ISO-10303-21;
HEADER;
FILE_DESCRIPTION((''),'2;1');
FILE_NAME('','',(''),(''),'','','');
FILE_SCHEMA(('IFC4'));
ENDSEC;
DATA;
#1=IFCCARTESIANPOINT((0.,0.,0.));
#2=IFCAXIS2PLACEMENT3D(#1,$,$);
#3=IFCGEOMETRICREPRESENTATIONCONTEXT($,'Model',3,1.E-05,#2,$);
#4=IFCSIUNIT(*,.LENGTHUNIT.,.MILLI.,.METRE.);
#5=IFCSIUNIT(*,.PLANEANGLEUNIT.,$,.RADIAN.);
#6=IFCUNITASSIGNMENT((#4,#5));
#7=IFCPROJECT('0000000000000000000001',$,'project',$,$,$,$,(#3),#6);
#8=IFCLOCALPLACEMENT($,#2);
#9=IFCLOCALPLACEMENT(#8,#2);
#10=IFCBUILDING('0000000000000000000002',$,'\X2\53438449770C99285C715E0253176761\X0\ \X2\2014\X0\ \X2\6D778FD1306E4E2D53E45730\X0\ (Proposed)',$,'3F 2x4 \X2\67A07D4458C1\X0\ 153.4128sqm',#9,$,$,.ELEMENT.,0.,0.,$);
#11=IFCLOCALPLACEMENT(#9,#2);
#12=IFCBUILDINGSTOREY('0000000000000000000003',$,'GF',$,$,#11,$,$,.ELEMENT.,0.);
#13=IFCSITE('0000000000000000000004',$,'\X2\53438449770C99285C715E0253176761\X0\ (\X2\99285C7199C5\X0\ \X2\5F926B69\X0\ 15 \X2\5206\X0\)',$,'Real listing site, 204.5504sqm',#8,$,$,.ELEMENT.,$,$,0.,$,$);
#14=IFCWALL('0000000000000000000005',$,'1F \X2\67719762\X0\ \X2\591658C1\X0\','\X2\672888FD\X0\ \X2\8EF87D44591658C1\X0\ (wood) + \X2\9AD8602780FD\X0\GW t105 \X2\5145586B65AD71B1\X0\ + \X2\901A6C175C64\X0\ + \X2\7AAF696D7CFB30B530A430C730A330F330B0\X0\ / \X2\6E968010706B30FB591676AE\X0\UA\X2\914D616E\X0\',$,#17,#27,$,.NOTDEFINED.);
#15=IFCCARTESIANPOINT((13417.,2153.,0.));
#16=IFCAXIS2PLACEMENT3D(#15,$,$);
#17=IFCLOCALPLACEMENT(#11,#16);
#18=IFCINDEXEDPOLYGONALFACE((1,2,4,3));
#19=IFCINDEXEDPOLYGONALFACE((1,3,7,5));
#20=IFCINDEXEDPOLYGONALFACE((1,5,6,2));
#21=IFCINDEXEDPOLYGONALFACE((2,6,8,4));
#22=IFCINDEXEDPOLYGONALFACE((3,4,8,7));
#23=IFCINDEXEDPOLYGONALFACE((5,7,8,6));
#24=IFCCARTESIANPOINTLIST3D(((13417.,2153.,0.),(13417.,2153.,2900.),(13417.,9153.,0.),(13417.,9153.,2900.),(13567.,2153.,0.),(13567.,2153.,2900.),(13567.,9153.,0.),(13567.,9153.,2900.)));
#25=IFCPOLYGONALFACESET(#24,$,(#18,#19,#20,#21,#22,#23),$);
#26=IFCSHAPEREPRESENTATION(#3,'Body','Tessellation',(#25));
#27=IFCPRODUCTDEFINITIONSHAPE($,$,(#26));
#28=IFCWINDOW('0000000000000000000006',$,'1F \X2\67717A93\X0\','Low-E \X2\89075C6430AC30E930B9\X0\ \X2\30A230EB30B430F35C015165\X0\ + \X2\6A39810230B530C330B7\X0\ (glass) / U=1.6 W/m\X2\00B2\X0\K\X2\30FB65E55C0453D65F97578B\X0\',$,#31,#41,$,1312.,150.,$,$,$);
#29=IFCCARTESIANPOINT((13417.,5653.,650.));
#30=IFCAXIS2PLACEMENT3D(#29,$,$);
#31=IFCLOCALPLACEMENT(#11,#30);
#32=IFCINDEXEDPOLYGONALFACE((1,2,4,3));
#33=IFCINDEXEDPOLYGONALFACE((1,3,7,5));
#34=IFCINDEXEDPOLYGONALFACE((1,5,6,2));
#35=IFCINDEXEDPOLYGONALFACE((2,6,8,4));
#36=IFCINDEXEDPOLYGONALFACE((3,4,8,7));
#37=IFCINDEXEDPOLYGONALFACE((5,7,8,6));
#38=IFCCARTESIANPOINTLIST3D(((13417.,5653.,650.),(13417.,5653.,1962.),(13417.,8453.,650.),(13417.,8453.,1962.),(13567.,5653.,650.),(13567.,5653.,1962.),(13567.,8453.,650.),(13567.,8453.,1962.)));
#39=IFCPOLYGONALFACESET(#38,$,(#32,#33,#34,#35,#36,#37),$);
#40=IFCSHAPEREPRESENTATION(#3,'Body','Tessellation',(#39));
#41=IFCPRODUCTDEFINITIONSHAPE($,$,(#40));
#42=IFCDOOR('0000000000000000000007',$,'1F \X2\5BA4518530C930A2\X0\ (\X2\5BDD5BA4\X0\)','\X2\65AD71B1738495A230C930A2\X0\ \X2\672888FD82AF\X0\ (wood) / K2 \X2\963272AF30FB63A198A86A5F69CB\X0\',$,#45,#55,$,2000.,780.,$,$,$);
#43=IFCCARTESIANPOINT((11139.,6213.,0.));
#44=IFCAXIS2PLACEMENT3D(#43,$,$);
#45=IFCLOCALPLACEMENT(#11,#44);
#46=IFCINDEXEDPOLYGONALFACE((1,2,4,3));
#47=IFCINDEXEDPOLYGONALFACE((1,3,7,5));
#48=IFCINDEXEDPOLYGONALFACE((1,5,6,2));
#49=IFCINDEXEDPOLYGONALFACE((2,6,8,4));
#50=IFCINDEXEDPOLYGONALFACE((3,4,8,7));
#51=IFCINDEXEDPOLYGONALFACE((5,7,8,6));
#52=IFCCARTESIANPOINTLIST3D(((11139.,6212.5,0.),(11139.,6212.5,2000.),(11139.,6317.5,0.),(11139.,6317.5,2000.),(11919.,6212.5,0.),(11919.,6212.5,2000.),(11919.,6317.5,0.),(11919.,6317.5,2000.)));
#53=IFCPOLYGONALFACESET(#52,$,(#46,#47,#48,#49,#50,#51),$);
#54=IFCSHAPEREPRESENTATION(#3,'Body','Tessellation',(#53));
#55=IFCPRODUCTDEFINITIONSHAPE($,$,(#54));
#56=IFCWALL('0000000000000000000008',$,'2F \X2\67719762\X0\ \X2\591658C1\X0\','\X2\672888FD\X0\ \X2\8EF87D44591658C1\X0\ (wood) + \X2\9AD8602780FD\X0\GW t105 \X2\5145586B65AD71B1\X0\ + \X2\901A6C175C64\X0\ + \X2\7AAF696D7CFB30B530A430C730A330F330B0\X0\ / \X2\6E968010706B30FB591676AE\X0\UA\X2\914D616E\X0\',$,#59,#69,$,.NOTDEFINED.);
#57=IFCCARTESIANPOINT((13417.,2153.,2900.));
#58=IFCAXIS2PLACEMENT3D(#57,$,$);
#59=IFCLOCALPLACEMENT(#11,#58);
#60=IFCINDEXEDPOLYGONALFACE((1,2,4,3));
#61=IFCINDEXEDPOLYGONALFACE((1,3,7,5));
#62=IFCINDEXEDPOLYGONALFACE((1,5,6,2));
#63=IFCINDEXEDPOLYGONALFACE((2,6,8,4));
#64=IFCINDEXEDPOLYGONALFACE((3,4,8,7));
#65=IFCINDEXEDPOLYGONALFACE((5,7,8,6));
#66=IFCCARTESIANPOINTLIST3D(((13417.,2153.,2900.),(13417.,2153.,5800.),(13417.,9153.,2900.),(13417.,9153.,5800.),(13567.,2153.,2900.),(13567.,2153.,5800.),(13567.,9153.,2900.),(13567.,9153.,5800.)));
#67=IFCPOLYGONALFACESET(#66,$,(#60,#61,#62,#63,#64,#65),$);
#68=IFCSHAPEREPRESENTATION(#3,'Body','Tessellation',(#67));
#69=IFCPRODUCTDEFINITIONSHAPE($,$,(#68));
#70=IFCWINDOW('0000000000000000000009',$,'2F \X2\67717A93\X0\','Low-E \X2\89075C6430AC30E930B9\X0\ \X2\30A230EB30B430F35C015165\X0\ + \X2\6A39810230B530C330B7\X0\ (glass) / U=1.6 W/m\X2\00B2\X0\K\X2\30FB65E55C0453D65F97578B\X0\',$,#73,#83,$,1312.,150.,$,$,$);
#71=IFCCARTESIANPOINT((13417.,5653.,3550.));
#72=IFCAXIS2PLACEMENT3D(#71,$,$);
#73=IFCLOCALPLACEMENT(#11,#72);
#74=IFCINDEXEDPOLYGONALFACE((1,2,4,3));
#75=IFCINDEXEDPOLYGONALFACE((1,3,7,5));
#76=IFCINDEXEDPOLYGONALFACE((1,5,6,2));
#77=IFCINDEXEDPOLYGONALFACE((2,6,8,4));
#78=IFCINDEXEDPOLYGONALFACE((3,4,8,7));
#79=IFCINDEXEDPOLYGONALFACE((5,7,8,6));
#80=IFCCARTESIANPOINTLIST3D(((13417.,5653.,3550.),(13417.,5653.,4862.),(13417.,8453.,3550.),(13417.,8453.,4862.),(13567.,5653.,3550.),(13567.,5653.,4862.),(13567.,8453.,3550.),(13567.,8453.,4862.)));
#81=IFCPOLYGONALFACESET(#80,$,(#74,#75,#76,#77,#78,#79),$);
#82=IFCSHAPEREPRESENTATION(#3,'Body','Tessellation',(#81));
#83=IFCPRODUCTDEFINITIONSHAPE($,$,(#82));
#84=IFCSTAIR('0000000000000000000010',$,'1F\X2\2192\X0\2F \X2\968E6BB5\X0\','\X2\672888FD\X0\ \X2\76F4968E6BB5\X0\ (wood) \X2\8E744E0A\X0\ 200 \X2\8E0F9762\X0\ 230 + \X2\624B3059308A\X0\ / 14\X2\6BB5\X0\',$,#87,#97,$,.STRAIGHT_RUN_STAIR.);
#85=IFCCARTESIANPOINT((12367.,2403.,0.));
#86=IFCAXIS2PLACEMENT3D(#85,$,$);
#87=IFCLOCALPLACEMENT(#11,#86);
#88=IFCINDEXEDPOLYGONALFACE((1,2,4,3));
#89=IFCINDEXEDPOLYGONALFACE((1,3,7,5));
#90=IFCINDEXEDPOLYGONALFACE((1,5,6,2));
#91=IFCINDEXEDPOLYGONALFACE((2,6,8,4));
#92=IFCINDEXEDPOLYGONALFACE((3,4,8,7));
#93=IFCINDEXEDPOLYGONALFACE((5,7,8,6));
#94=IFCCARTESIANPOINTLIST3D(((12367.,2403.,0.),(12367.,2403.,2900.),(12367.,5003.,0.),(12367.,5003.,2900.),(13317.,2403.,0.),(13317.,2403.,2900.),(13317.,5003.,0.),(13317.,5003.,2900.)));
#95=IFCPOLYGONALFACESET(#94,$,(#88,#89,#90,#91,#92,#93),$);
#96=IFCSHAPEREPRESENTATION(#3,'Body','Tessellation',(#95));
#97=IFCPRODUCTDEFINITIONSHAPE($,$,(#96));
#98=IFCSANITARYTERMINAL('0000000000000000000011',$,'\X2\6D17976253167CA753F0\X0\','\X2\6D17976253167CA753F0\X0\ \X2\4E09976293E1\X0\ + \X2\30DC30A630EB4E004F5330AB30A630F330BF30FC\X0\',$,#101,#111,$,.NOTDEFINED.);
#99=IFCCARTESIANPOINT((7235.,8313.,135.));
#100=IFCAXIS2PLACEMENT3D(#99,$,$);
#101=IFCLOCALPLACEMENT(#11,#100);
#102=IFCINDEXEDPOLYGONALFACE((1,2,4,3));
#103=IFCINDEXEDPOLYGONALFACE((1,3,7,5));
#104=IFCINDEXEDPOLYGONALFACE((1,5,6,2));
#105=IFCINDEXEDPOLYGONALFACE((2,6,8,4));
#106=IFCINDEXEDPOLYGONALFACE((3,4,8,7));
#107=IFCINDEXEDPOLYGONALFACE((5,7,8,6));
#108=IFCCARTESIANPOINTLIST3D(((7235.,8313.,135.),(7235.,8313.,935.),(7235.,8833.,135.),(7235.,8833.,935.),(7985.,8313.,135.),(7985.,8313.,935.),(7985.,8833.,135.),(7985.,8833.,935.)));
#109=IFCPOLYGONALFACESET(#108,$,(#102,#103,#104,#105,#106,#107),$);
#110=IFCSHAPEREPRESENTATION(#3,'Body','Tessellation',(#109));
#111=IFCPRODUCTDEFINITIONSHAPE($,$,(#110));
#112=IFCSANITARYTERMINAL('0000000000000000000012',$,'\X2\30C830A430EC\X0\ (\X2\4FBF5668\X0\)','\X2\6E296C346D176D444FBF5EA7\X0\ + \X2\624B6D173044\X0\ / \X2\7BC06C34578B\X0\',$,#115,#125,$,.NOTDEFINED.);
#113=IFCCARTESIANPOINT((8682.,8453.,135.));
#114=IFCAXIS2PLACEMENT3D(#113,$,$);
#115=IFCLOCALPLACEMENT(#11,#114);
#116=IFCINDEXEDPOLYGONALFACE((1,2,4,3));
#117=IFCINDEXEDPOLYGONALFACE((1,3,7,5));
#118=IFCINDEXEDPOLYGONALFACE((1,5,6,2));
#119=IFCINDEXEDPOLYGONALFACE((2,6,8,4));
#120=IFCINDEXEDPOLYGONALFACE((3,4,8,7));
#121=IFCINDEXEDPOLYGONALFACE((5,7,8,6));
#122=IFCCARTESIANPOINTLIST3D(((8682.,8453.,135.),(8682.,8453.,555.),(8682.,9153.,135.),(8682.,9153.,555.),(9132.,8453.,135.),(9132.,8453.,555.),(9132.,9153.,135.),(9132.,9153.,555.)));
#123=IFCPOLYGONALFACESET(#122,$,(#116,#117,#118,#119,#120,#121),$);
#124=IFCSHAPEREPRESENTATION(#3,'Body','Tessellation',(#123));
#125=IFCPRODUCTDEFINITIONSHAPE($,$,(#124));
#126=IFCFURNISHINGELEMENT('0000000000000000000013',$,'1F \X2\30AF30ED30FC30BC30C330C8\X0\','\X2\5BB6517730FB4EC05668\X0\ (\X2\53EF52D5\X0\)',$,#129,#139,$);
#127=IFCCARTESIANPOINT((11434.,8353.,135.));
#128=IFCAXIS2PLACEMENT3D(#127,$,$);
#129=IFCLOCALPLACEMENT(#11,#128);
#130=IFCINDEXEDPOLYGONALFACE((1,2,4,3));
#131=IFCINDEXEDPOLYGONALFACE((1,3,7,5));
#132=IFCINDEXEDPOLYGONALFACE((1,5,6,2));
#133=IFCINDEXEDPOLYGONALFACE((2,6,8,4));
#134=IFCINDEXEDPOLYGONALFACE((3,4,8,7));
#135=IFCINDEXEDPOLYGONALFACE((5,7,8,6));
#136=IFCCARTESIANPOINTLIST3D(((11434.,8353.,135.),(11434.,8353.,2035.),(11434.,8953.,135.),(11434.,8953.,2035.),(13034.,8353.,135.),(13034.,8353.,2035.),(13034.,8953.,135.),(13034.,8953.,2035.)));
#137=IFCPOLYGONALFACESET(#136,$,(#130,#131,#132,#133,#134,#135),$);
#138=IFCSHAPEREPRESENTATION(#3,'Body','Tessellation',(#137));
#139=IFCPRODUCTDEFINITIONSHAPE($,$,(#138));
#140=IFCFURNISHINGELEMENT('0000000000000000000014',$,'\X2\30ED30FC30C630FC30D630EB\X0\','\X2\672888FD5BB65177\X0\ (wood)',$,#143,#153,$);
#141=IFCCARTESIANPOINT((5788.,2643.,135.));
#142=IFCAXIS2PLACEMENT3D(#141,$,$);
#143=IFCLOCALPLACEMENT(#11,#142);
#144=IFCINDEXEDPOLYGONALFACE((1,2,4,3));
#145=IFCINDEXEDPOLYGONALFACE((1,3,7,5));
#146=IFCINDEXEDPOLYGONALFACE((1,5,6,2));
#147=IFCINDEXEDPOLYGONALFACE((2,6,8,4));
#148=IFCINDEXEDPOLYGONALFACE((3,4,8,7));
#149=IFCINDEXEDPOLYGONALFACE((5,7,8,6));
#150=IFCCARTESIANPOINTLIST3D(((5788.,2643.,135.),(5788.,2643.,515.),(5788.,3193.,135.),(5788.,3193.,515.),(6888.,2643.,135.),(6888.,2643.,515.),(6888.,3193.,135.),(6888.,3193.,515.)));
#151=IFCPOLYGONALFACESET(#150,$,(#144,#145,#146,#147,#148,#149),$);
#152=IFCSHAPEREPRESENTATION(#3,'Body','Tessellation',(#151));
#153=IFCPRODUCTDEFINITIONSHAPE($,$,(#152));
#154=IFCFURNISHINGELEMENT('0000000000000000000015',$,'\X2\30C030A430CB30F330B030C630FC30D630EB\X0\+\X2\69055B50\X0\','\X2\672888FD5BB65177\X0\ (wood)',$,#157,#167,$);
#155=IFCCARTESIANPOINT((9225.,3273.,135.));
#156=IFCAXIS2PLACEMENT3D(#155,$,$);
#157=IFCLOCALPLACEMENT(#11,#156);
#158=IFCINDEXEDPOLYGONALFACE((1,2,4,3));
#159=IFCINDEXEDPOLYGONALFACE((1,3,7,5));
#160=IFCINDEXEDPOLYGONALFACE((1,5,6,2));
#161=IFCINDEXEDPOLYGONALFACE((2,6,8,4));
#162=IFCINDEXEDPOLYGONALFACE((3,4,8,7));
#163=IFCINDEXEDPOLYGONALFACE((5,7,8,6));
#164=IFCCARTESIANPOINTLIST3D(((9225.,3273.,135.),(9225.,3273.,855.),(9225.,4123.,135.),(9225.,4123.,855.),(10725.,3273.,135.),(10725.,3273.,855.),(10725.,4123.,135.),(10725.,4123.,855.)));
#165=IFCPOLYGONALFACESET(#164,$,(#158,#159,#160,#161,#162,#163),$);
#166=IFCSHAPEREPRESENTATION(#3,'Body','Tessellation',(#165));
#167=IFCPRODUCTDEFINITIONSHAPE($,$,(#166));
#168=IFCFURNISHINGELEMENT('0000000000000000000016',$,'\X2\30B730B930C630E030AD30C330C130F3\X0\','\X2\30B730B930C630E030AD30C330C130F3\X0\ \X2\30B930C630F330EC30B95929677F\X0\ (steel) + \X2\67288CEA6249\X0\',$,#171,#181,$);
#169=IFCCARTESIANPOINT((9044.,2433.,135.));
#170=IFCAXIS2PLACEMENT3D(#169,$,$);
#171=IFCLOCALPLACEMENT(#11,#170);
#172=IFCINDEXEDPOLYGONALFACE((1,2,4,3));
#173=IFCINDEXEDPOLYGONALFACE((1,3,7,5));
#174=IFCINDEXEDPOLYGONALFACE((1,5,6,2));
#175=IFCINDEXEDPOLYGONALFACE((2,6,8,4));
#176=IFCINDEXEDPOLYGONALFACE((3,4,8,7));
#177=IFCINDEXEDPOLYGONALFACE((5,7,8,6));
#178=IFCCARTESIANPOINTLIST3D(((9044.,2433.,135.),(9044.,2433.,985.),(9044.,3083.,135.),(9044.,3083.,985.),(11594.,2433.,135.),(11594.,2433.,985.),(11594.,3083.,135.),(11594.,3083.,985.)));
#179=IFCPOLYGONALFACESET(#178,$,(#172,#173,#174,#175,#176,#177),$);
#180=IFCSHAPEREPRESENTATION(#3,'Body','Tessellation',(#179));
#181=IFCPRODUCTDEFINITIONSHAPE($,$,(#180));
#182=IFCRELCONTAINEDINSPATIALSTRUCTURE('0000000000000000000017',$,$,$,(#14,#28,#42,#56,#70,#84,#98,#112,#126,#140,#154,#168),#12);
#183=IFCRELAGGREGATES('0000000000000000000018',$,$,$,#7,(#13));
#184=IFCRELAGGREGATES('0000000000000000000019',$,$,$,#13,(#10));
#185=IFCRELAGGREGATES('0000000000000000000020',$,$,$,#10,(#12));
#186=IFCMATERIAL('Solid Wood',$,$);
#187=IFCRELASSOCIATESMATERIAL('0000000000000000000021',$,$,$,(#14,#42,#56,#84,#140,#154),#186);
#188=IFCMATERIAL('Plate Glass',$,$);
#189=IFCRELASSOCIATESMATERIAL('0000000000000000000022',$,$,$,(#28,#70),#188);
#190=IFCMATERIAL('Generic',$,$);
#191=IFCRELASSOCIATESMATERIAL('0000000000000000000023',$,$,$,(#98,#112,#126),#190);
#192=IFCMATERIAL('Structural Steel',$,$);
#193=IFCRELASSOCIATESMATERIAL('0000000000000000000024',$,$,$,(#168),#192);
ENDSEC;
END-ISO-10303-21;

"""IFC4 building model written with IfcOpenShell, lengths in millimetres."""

from ifc_helpers import new_model, si_unit, frame, frame_2d, origin, place, context, project, spatial, rectangle, extrude, material, element, fill, save


model = new_model("IFC4")

# Units and contexts
model_context = context("Model", 3, precision=1e-05, world=origin())
ifc_project = project(units=[si_unit("LENGTHUNIT", "METRE", prefix="MILLI"), si_unit("PLANEANGLEUNIT", "RADIAN")], contexts=[model_context])

# Site, building, storey
site_placement = place(None, origin())
site = spatial("IfcSite", under=ifc_project, at=site_placement, Name="千葉県館山市北条 (館山駅 徒歩 15 分)", ObjectType="Real listing site, 204.5504sqm", CompositionType="ELEMENT", RefElevation=0.0)
building_placement = place(site_placement, origin())
building = spatial("IfcBuilding", under=site, at=building_placement, Name="千葉県館山市北条 — 海近の中古地 (Proposed)", ObjectType="3F 2x4 枠組壁 153.4128sqm", CompositionType="ELEMENT", ElevationOfRefHeight=0.0, ElevationOfTerrain=0.0)
storey_placement = place(building_placement, origin())
storey = spatial("IfcBuildingStorey", under=building, at=storey_placement, Name="GF", CompositionType="ELEMENT", Elevation=0.0)

# Wall, opening, window
ifc_material_1 = material(Name="Solid Wood")
wall_1_placement = place(storey_placement, frame((13417.0, 2153.0, 0.0)))
wall_1 = element("IfcWall", 1, at=wall_1_placement, inside=storey, material=ifc_material_1, Name="1F 東面 外壁", Description="木製 軸組外壁 (wood) + 高性能GW t105 充填断熱 + 通気層 + 窯業系サイディング / 準耐火・外皮UA配慮", PredefinedType="NOTDEFINED", context=model_context, shape_type="SweptSolid", body=[
    extrude(rectangle(XDim=150.0, YDim=7000.0, at=frame_2d((75.0, 3500.0))), frame((13417.0, 2153.0, 0.0)), (0.0, 0.0, 1.0), 2900.0),
])
opening_1_placement = place(storey_placement, frame((13417.0, 5653.0, 650.0)))
opening_1 = element("IfcOpeningElement", 2, at=opening_1_placement, cuts=wall_1, PredefinedType="NOTDEFINED", context=model_context, shape_type="SweptSolid", body=[
    extrude(rectangle(XDim=150.0, YDim=2800.0, at=frame_2d((75.0, 1400.0))), frame((13417.0, 5653.0, 650.0)), (0.0, 0.0, 1.0), 1312.0),
])
ifc_material_2 = material(Name="Plate Glass")
window_1_placement = place(storey_placement, frame((13417.0, 5653.0, 650.0)))
window_1 = element("IfcWindow", 3, at=window_1_placement, inside=storey, material=ifc_material_2, Name="1F 東窓", Description="Low-E 複層ガラス アルゴン封入 + 樹脂サッシ (glass) / U=1.6 W/m²K・日射取得型", OverallHeight=1312.0, OverallWidth=150.0, context=model_context, shape_type="SweptSolid", body=[
    extrude(rectangle(XDim=150.0, YDim=2800.0, at=frame_2d((75.0, 1400.0))), frame((13417.0, 5653.0, 650.0)), (0.0, 0.0, 1.0), 1312.0),
])
fill(opening_1, window_1)

# Door
door_placement = place(storey_placement, frame((11139.0, 6213.0, 0.0)))
element("IfcDoor", 4, at=door_placement, inside=storey, material=ifc_material_1, Name="1F 室内ドア (寝室)", Description="断熱玄関ドア 木製芯 (wood) / K2 防犯・採風機構", OverallHeight=2000.0, OverallWidth=780.0, context=model_context, shape_type="SweptSolid", body=[
    extrude(rectangle(XDim=780.0, YDim=105.0, at=frame_2d((390.0, 52.0))), frame((11139.0, 6213.0, 0.0)), (0.0, 0.0, 1.0), 2000.0),
])

# Wall, opening, window
wall_2_placement = place(storey_placement, frame((13417.0, 2153.0, 2900.0)))
wall_2 = element("IfcWall", 5, at=wall_2_placement, inside=storey, material=ifc_material_1, Name="2F 東面 外壁", Description="木製 軸組外壁 (wood) + 高性能GW t105 充填断熱 + 通気層 + 窯業系サイディング / 準耐火・外皮UA配慮", PredefinedType="NOTDEFINED", context=model_context, shape_type="SweptSolid", body=[
    extrude(rectangle(XDim=150.0, YDim=7000.0, at=frame_2d((75.0, 3500.0))), frame((13417.0, 2153.0, 2900.0)), (0.0, 0.0, 1.0), 2900.0),
])
opening_2_placement = place(storey_placement, frame((13417.0, 5653.0, 3550.0)))
opening_2 = element("IfcOpeningElement", 6, at=opening_2_placement, cuts=wall_2, PredefinedType="NOTDEFINED", context=model_context, shape_type="SweptSolid", body=[
    extrude(rectangle(XDim=150.0, YDim=2800.0, at=frame_2d((75.0, 1400.0))), frame((13417.0, 5653.0, 3550.0)), (0.0, 0.0, 1.0), 1312.0),
])
window_2_placement = place(storey_placement, frame((13417.0, 5653.0, 3550.0)))
window_2 = element("IfcWindow", 7, at=window_2_placement, inside=storey, material=ifc_material_2, Name="2F 東窓", Description="Low-E 複層ガラス アルゴン封入 + 樹脂サッシ (glass) / U=1.6 W/m²K・日射取得型", OverallHeight=1312.0, OverallWidth=150.0, context=model_context, shape_type="SweptSolid", body=[
    extrude(rectangle(XDim=150.0, YDim=2800.0, at=frame_2d((75.0, 1400.0))), frame((13417.0, 5653.0, 3550.0)), (0.0, 0.0, 1.0), 1312.0),
])
fill(opening_2, window_2)

# Stair
stair_placement = place(storey_placement, frame((12367.0, 2403.0, 0.0)))
element("IfcStair", 8, at=stair_placement, inside=storey, material=ifc_material_1, Name="1F→2F 階段", Description="木製 直階段 (wood) 蹴上 200 踏面 230 + 手すり / 14段", PredefinedType="STRAIGHT_RUN_STAIR", context=model_context, shape_type="SweptSolid", body=[
    extrude(rectangle(XDim=950.0, YDim=2600.0, at=frame_2d((475.0, 1300.0))), frame((12367.0, 2403.0, 0.0)), (0.0, 0.0, 1.0), 2900.0),
])

# Sanitary terminals
ifc_material_3 = material(Name="Generic")
sanitary_terminal_1_placement = place(storey_placement, frame((7235.0, 8313.0, 135.0)))
element("IfcSanitaryTerminal", 9, at=sanitary_terminal_1_placement, inside=storey, material=ifc_material_3, Name="洗面化粧台", Description="洗面化粧台 三面鏡 + ボウル一体カウンター", PredefinedType="NOTDEFINED", context=model_context, shape_type="SweptSolid", body=[
    extrude(rectangle(XDim=750.0, YDim=520.0, at=frame_2d((375.0, 260.0))), frame((7235.0, 8313.0, 135.0)), (0.0, 0.0, 1.0), 800.0),
])
sanitary_terminal_2_placement = place(storey_placement, frame((8682.0, 8453.0, 135.0)))
element("IfcSanitaryTerminal", 10, at=sanitary_terminal_2_placement, inside=storey, material=ifc_material_3, Name="トイレ (便器)", Description="温水洗浄便座 + 手洗い / 節水型", PredefinedType="NOTDEFINED", context=model_context, shape_type="SweptSolid", body=[
    extrude(rectangle(XDim=450.0, YDim=700.0, at=frame_2d((225.0, 350.0))), frame((8682.0, 8453.0, 135.0)), (0.0, 0.0, 1.0), 420.0),
])

# Furnishing elements
furnishing_1_placement = place(storey_placement, frame((11434.0, 8353.0, 135.0)))
element("IfcFurnishingElement", 11, at=furnishing_1_placement, inside=storey, material=ifc_material_3, Name="1F クローゼット", Description="家具・什器 (可動)", context=model_context, shape_type="SweptSolid", body=[
    extrude(rectangle(XDim=1600.0, YDim=600.0, at=frame_2d((800.0, 300.0))), frame((11434.0, 8353.0, 135.0)), (0.0, 0.0, 1.0), 1900.0),
])
furnishing_2_placement = place(storey_placement, frame((5788.0, 2643.0, 135.0)))
element("IfcFurnishingElement", 12, at=furnishing_2_placement, inside=storey, material=ifc_material_1, Name="ローテーブル", Description="木製家具 (wood)", context=model_context, shape_type="SweptSolid", body=[
    extrude(rectangle(XDim=1100.0, YDim=550.0, at=frame_2d((550.0, 275.0))), frame((5788.0, 2643.0, 135.0)), (0.0, 0.0, 1.0), 380.0),
])
furnishing_3_placement = place(storey_placement, frame((9225.0, 3273.0, 135.0)))
element("IfcFurnishingElement", 13, at=furnishing_3_placement, inside=storey, material=ifc_material_1, Name="ダイニングテーブル+椅子", Description="木製家具 (wood)", context=model_context, shape_type="SweptSolid", body=[
    extrude(rectangle(XDim=1500.0, YDim=850.0, at=frame_2d((750.0, 425.0))), frame((9225.0, 3273.0, 135.0)), (0.0, 0.0, 1.0), 720.0),
])
ifc_material_4 = material(Name="Structural Steel")
furnishing_4_placement = place(storey_placement, frame((9044.0, 2433.0, 135.0)))
element("IfcFurnishingElement", 14, at=furnishing_4_placement, inside=storey, material=ifc_material_4, Name="システムキッチン", Description="システムキッチン ステンレス天板 (steel) + 木質扉", context=model_context, shape_type="SweptSolid", body=[
    extrude(rectangle(XDim=2550.0, YDim=650.0, at=frame_2d((1275.0, 325.0))), frame((9044.0, 2433.0, 135.0)), (0.0, 0.0, 1.0), 850.0),
])

save(model, "model.ifc")
